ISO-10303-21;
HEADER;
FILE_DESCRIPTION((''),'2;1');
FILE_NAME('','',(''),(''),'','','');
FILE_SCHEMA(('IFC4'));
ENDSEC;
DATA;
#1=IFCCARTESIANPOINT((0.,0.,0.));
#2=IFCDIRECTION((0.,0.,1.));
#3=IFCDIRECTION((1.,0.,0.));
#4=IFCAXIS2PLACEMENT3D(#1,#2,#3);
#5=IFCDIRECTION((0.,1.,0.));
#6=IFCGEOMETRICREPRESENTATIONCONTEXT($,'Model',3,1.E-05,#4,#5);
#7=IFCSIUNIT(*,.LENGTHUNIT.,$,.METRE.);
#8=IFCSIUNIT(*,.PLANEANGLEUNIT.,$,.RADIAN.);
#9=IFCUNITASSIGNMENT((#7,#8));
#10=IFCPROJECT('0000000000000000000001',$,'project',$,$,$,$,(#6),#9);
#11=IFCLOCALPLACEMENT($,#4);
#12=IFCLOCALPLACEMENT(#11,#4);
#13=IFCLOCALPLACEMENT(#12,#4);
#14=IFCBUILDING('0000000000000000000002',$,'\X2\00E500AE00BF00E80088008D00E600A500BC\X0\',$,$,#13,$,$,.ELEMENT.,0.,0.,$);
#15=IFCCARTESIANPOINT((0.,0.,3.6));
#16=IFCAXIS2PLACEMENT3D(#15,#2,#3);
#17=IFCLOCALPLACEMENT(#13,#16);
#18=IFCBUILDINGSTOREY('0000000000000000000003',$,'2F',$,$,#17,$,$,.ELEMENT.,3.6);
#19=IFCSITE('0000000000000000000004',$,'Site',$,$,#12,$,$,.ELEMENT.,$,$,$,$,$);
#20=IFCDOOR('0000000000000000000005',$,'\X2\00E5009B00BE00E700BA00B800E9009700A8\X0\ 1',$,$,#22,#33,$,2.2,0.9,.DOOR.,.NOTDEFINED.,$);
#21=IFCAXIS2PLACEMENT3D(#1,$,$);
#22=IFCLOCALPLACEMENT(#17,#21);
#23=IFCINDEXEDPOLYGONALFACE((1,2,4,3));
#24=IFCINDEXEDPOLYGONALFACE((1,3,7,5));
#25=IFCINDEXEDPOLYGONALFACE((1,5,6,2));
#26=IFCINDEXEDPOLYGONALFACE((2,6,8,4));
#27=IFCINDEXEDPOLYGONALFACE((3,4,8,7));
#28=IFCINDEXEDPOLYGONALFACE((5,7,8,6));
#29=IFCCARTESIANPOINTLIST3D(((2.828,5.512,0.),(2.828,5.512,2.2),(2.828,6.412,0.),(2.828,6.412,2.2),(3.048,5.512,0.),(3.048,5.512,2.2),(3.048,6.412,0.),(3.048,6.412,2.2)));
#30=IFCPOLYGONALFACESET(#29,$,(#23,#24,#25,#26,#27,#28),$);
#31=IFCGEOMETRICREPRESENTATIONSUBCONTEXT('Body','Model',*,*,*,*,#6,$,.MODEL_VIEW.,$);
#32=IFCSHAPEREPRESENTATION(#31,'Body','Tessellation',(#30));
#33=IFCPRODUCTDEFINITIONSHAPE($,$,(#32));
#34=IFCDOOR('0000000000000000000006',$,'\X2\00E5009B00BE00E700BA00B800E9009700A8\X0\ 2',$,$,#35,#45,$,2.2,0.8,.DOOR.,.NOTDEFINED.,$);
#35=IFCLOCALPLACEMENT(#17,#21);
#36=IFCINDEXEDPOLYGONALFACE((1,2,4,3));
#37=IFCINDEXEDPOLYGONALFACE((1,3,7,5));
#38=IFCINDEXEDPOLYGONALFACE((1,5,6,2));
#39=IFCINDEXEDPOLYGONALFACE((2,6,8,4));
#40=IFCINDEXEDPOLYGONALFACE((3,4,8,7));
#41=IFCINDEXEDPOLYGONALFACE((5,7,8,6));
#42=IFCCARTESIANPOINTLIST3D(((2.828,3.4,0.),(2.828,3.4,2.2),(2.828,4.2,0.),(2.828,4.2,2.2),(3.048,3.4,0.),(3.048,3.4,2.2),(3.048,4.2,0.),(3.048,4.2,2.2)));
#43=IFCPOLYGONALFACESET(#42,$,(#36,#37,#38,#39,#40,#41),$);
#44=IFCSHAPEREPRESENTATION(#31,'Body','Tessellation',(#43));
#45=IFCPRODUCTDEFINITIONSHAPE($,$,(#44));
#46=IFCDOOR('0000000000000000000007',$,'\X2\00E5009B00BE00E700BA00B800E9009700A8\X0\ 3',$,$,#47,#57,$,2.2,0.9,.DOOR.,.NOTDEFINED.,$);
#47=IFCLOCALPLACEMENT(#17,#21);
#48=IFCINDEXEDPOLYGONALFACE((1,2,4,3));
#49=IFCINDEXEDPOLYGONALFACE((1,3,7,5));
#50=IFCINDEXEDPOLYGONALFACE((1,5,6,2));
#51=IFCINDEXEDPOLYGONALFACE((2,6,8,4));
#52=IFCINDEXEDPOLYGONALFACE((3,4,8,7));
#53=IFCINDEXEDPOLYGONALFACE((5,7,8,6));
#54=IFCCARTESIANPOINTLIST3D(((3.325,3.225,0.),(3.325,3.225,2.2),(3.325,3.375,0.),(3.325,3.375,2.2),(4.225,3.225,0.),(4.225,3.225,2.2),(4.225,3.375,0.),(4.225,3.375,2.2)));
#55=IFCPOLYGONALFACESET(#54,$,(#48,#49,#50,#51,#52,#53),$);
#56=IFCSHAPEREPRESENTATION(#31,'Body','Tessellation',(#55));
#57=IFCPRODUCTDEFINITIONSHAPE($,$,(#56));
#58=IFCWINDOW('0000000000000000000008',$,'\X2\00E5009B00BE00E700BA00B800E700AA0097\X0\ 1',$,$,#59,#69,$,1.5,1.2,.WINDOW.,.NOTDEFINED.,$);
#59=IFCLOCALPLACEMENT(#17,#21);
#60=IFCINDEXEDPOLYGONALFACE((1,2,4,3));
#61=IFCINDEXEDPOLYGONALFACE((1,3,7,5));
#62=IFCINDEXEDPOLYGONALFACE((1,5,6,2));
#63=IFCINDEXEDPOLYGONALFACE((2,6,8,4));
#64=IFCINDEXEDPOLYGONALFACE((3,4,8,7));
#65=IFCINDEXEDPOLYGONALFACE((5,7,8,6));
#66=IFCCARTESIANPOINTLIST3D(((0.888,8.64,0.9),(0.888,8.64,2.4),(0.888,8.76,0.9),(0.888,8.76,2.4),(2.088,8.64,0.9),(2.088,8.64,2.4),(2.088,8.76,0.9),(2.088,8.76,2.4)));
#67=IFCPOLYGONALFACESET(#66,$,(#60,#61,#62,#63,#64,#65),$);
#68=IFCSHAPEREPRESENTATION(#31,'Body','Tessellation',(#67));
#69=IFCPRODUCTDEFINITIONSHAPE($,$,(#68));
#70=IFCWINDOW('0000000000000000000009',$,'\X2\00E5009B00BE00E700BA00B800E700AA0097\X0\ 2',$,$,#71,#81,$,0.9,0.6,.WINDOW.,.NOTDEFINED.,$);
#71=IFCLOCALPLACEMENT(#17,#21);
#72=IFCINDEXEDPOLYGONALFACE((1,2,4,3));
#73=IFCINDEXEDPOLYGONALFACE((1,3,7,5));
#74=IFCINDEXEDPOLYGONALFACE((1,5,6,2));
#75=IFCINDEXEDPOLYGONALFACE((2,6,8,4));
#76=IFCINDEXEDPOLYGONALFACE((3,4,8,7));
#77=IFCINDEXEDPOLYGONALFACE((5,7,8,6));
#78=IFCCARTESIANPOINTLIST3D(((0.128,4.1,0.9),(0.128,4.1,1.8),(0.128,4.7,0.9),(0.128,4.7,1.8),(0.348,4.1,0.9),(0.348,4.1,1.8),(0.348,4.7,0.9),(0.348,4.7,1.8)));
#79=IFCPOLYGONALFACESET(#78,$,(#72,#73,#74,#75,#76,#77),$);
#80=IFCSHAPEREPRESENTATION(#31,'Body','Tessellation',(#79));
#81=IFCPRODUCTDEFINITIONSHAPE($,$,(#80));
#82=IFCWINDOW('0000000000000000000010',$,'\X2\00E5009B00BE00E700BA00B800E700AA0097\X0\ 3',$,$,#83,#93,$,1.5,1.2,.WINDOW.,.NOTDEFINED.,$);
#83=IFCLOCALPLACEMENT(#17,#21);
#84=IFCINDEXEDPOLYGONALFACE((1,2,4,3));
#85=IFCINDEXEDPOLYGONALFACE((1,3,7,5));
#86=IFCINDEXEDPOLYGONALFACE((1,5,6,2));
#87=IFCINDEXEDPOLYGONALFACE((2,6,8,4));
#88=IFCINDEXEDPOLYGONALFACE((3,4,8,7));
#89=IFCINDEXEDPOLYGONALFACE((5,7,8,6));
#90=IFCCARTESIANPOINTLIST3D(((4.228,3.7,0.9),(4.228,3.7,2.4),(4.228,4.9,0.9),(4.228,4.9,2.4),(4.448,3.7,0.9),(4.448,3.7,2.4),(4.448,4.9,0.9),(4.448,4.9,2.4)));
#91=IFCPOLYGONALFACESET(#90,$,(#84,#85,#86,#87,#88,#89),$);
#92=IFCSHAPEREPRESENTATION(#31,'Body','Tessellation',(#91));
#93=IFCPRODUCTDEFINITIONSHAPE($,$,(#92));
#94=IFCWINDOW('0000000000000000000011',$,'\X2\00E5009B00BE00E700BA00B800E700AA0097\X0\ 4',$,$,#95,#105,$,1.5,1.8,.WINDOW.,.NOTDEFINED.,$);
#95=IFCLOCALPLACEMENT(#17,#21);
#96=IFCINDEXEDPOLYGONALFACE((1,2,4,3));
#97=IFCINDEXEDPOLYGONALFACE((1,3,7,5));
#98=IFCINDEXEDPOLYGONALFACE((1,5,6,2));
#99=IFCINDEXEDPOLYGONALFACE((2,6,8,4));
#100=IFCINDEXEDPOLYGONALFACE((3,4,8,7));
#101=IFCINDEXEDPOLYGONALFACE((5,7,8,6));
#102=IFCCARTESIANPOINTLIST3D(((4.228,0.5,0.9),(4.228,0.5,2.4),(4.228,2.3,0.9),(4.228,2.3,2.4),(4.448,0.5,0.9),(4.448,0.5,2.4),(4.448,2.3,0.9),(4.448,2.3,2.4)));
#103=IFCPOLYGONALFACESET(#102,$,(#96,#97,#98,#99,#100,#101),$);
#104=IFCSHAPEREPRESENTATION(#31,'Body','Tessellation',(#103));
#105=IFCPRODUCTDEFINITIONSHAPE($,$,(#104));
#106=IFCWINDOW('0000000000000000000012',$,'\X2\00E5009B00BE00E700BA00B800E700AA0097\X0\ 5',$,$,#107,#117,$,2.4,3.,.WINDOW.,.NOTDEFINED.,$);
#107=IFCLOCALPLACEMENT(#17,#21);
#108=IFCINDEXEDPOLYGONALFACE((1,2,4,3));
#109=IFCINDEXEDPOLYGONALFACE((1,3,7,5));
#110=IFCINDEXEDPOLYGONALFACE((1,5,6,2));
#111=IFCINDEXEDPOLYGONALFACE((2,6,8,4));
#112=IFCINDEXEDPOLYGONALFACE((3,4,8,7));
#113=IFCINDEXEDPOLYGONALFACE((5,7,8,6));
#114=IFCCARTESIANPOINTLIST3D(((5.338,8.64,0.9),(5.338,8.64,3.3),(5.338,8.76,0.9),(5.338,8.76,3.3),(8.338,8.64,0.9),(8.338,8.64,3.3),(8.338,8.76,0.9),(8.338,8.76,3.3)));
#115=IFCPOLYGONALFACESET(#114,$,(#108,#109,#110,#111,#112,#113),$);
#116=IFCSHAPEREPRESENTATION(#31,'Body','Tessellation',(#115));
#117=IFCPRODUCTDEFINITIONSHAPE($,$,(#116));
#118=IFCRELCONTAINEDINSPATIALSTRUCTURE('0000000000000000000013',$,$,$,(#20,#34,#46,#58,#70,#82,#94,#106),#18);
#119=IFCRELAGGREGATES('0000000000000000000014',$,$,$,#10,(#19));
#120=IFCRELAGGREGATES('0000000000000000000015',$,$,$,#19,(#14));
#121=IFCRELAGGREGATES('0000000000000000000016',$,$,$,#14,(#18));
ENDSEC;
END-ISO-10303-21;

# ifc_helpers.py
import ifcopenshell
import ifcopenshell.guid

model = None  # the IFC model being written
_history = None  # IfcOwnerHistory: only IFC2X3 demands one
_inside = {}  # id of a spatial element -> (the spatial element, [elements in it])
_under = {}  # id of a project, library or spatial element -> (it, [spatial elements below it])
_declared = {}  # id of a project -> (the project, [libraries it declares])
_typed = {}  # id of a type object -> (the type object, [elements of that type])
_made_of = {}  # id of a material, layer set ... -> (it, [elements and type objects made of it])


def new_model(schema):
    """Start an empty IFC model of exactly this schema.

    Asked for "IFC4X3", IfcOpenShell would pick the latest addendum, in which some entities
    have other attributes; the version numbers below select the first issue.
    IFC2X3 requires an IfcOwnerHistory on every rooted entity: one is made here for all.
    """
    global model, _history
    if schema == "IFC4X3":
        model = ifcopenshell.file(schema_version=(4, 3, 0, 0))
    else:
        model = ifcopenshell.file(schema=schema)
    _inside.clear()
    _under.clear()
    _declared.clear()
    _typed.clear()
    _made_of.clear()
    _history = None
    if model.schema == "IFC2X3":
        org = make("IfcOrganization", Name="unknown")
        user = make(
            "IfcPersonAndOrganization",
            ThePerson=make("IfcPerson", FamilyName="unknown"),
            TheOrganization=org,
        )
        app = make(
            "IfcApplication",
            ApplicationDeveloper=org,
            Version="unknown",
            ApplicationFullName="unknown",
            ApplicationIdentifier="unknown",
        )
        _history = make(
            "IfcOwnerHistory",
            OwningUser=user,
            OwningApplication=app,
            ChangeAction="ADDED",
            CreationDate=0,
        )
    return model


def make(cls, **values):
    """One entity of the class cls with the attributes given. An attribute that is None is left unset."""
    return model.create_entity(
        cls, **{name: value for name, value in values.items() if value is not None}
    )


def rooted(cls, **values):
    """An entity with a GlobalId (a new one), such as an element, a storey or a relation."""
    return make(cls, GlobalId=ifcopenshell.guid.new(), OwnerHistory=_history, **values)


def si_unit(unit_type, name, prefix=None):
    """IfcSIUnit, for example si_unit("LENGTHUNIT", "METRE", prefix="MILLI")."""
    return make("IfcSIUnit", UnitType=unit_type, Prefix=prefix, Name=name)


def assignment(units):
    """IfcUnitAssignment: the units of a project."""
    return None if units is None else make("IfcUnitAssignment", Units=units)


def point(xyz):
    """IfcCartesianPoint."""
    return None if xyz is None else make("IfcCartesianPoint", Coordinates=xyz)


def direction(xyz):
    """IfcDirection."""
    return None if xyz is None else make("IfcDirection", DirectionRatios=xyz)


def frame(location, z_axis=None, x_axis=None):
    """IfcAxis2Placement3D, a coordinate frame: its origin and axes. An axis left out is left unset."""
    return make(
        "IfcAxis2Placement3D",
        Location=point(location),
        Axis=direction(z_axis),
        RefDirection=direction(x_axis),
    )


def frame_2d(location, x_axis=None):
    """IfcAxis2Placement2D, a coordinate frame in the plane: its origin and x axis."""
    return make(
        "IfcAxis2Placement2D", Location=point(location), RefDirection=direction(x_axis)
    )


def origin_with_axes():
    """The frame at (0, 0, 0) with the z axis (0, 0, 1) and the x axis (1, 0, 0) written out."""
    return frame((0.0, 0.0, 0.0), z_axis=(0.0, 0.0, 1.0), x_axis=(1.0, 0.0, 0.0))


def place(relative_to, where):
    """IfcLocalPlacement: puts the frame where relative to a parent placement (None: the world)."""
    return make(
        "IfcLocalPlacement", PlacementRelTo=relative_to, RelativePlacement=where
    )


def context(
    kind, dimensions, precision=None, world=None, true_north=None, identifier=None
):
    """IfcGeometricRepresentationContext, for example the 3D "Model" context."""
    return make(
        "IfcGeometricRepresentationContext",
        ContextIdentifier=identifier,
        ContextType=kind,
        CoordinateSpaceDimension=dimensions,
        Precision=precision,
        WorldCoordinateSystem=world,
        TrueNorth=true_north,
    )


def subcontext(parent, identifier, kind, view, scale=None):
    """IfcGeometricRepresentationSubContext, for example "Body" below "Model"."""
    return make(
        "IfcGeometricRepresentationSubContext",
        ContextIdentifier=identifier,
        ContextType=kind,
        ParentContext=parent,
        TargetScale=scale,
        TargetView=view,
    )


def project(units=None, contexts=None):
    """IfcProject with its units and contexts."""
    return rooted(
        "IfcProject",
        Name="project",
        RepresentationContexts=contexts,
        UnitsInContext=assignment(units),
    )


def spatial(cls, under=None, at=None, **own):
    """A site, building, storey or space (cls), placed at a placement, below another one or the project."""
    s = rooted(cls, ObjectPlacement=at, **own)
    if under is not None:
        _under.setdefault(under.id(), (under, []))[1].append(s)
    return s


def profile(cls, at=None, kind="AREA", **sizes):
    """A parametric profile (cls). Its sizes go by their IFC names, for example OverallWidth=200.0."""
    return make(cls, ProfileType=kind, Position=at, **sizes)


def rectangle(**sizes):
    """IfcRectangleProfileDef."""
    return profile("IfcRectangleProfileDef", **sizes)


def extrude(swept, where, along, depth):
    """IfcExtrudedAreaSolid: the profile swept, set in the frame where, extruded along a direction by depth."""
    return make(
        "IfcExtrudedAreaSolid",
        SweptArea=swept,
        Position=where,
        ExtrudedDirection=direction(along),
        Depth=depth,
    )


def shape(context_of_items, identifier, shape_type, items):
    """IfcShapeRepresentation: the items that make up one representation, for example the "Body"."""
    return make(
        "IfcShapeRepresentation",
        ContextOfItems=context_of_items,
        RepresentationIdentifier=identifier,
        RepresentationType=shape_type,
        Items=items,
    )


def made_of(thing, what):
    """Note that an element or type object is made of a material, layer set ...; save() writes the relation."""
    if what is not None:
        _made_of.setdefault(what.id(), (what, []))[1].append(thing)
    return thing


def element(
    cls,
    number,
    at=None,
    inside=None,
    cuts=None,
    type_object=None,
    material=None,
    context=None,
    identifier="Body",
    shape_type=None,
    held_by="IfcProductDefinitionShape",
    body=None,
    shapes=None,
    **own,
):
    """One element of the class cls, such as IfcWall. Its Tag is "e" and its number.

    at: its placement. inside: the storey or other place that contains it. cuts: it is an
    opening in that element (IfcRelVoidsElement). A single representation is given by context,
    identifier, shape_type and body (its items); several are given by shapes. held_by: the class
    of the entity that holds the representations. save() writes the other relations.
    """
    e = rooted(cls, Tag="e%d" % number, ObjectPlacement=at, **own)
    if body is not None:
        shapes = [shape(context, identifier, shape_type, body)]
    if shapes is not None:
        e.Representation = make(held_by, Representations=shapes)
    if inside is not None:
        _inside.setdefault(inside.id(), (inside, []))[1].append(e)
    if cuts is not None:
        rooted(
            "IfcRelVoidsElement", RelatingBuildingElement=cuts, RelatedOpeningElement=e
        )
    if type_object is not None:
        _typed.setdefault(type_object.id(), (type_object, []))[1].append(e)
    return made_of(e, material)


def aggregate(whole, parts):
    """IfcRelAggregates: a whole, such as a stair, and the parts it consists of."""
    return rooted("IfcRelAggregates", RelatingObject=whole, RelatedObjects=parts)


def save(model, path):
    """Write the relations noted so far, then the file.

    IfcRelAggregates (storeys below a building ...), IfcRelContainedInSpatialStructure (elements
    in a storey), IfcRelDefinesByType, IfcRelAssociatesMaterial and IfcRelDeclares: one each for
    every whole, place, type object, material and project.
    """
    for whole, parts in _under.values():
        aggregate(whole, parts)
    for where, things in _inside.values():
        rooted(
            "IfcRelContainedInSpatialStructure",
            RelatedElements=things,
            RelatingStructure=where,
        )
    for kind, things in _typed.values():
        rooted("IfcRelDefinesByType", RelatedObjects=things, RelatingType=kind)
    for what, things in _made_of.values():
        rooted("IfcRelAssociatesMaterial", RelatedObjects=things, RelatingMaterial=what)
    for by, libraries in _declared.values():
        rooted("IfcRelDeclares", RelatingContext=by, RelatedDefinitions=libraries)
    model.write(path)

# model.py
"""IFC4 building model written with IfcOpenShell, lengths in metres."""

from ifc_helpers import new_model, si_unit, direction, frame, frame_2d, origin_with_axes, place, context, subcontext, project, spatial, rectangle, extrude, element, save


model = new_model("IFC4")

# Units and contexts
model_context = context("Model", 3, precision=1e-05, world=origin_with_axes(), true_north=direction((0.0, 1.0, 0.0)))
body_context = subcontext(model_context, "Body", "Model", "MODEL_VIEW")
ifc_project = project(units=[si_unit("LENGTHUNIT", "METRE"), si_unit("PLANEANGLEUNIT", "RADIAN")], contexts=[model_context])

# Site, building, storey
placement = place(None, origin_with_axes())
site_placement = place(placement, origin_with_axes())
site = spatial("IfcSite", under=ifc_project, at=site_placement, Name="Site", CompositionType="ELEMENT")
building_placement = place(site_placement, origin_with_axes())
building = spatial("IfcBuilding", under=site, at=building_placement, Name="å®¿è\u0088\u008dæ¥¼", CompositionType="ELEMENT", ElevationOfRefHeight=0.0, ElevationOfTerrain=0.0)
storey_placement = place(building_placement, frame((0.0, 0.0, 3.6), z_axis=(0.0, 0.0, 1.0), x_axis=(1.0, 0.0, 0.0)))
storey = spatial("IfcBuildingStorey", under=building, at=storey_placement, Name="2F", CompositionType="ELEMENT", Elevation=3.6)

# Doors
door_1_placement = place(storey_placement, frame((2.938, 5.962, 0.0), z_axis=(0.0, 0.0, 1.0), x_axis=(0.0, 1.0, 0.0)))
element("IfcDoor", 1, at=door_1_placement, inside=storey, Name="å\u009b¾çº¸é\u0097¨ 1", OperationType="NOTDEFINED", OverallHeight=2.2, OverallWidth=0.9, PredefinedType="DOOR", context=body_context, shape_type="SweptSolid", body=[
    extrude(rectangle(XDim=0.9, YDim=0.22, at=frame_2d((0.0, 0.0), x_axis=(1.0, 0.0, 0.0))), frame((0.0, 0.0, 0.0), z_axis=(0.0, 0.0, 1.0)), (0.0, 0.0, 1.0), 2.2),
])
door_2_placement = place(storey_placement, frame((2.938, 3.8, 0.0), z_axis=(0.0, 0.0, 1.0), x_axis=(0.0, 1.0, 0.0)))
element("IfcDoor", 2, at=door_2_placement, inside=storey, Name="å\u009b¾çº¸é\u0097¨ 2", OperationType="NOTDEFINED", OverallHeight=2.2, OverallWidth=0.8, PredefinedType="DOOR", context=body_context, shape_type="SweptSolid", body=[
    extrude(rectangle(XDim=0.8, YDim=0.22, at=frame_2d((0.0, 0.0), x_axis=(1.0, 0.0, 0.0))), frame((0.0, 0.0, 0.0), z_axis=(0.0, 0.0, 1.0)), (0.0, 0.0, 1.0), 2.2),
])
door_3_placement = place(storey_placement, frame((3.775, 3.3, 0.0), z_axis=(0.0, 0.0, 1.0), x_axis=(1.0, 0.0, 0.0)))
element("IfcDoor", 3, at=door_3_placement, inside=storey, Name="å\u009b¾çº¸é\u0097¨ 3", OperationType="NOTDEFINED", OverallHeight=2.2, OverallWidth=0.9, PredefinedType="DOOR", context=body_context, shape_type="SweptSolid", body=[
    extrude(rectangle(XDim=0.9, YDim=0.15, at=frame_2d((0.0, 0.0), x_axis=(1.0, 0.0, 0.0))), frame((0.0, 0.0, 0.0), z_axis=(0.0, 0.0, 1.0)), (0.0, 0.0, 1.0), 2.2),
])

# Windows
window_1_placement = place(storey_placement, frame((1.488, 8.7, 0.9), z_axis=(0.0, 0.0, 1.0), x_axis=(1.0, 0.0, 0.0)))
element("IfcWindow", 4, at=window_1_placement, inside=storey, Name="å\u009b¾çº¸çª\u0097 1", OverallHeight=1.5, OverallWidth=1.2, PartitioningType="NOTDEFINED", PredefinedType="WINDOW", context=body_context, shape_type="SweptSolid", body=[
    extrude(rectangle(XDim=1.2, YDim=0.12, at=frame_2d((0.0, 0.0), x_axis=(1.0, 0.0, 0.0))), frame((0.0, 0.0, 0.0), z_axis=(0.0, 0.0, 1.0)), (0.0, 0.0, 1.0), 1.5),
])
window_2_placement = place(storey_placement, frame((0.238, 4.4, 0.9), z_axis=(0.0, 0.0, 1.0), x_axis=(0.0, 1.0, 0.0)))
element("IfcWindow", 5, at=window_2_placement, inside=storey, Name="å\u009b¾çº¸çª\u0097 2", OverallHeight=0.9, OverallWidth=0.6, PartitioningType="NOTDEFINED", PredefinedType="WINDOW", context=body_context, shape_type="SweptSolid", body=[
    extrude(rectangle(XDim=0.6, YDim=0.22, at=frame_2d((0.0, 0.0), x_axis=(1.0, 0.0, 0.0))), frame((0.0, 0.0, 0.0), z_axis=(0.0, 0.0, 1.0)), (0.0, 0.0, 1.0), 0.9),
])
window_3_placement = place(storey_placement, frame((4.338, 4.3, 0.9), z_axis=(0.0, 0.0, 1.0), x_axis=(0.0, 1.0, 0.0)))
element("IfcWindow", 6, at=window_3_placement, inside=storey, Name="å\u009b¾çº¸çª\u0097 3", OverallHeight=1.5, OverallWidth=1.2, PartitioningType="NOTDEFINED", PredefinedType="WINDOW", context=body_context, shape_type="SweptSolid", body=[
    extrude(rectangle(XDim=1.2, YDim=0.22, at=frame_2d((0.0, 0.0), x_axis=(1.0, 0.0, 0.0))), frame((0.0, 0.0, 0.0), z_axis=(0.0, 0.0, 1.0)), (0.0, 0.0, 1.0), 1.5),
])
window_4_placement = place(storey_placement, frame((4.338, 1.4, 0.9), z_axis=(0.0, 0.0, 1.0), x_axis=(0.0, 1.0, 0.0)))
element("IfcWindow", 7, at=window_4_placement, inside=storey, Name="å\u009b¾çº¸çª\u0097 4", OverallHeight=1.5, OverallWidth=1.8, PartitioningType="NOTDEFINED", PredefinedType="WINDOW", context=body_context, shape_type="SweptSolid", body=[
    extrude(rectangle(XDim=1.8, YDim=0.22, at=frame_2d((0.0, 0.0), x_axis=(1.0, 0.0, 0.0))), frame((0.0, 0.0, 0.0), z_axis=(0.0, 0.0, 1.0)), (0.0, 0.0, 1.0), 1.5),
])
window_5_placement = place(storey_placement, frame((6.838, 8.7, 0.9), z_axis=(0.0, 0.0, 1.0), x_axis=(-1.0, 0.0, 0.0)))
element("IfcWindow", 8, at=window_5_placement, inside=storey, Name="å\u009b¾çº¸çª\u0097 5", OverallHeight=2.4, OverallWidth=3.0, PartitioningType="NOTDEFINED", PredefinedType="WINDOW", context=body_context, shape_type="SweptSolid", body=[
    extrude(rectangle(XDim=3.0, YDim=0.12, at=frame_2d((0.0, 0.0), x_axis=(1.0, 0.0, 0.0))), frame((0.0, 0.0, 0.0), z_axis=(0.0, 0.0, 1.0)), (0.0, 0.0, 1.0), 2.4),
])

save(model, "model.ifc")
